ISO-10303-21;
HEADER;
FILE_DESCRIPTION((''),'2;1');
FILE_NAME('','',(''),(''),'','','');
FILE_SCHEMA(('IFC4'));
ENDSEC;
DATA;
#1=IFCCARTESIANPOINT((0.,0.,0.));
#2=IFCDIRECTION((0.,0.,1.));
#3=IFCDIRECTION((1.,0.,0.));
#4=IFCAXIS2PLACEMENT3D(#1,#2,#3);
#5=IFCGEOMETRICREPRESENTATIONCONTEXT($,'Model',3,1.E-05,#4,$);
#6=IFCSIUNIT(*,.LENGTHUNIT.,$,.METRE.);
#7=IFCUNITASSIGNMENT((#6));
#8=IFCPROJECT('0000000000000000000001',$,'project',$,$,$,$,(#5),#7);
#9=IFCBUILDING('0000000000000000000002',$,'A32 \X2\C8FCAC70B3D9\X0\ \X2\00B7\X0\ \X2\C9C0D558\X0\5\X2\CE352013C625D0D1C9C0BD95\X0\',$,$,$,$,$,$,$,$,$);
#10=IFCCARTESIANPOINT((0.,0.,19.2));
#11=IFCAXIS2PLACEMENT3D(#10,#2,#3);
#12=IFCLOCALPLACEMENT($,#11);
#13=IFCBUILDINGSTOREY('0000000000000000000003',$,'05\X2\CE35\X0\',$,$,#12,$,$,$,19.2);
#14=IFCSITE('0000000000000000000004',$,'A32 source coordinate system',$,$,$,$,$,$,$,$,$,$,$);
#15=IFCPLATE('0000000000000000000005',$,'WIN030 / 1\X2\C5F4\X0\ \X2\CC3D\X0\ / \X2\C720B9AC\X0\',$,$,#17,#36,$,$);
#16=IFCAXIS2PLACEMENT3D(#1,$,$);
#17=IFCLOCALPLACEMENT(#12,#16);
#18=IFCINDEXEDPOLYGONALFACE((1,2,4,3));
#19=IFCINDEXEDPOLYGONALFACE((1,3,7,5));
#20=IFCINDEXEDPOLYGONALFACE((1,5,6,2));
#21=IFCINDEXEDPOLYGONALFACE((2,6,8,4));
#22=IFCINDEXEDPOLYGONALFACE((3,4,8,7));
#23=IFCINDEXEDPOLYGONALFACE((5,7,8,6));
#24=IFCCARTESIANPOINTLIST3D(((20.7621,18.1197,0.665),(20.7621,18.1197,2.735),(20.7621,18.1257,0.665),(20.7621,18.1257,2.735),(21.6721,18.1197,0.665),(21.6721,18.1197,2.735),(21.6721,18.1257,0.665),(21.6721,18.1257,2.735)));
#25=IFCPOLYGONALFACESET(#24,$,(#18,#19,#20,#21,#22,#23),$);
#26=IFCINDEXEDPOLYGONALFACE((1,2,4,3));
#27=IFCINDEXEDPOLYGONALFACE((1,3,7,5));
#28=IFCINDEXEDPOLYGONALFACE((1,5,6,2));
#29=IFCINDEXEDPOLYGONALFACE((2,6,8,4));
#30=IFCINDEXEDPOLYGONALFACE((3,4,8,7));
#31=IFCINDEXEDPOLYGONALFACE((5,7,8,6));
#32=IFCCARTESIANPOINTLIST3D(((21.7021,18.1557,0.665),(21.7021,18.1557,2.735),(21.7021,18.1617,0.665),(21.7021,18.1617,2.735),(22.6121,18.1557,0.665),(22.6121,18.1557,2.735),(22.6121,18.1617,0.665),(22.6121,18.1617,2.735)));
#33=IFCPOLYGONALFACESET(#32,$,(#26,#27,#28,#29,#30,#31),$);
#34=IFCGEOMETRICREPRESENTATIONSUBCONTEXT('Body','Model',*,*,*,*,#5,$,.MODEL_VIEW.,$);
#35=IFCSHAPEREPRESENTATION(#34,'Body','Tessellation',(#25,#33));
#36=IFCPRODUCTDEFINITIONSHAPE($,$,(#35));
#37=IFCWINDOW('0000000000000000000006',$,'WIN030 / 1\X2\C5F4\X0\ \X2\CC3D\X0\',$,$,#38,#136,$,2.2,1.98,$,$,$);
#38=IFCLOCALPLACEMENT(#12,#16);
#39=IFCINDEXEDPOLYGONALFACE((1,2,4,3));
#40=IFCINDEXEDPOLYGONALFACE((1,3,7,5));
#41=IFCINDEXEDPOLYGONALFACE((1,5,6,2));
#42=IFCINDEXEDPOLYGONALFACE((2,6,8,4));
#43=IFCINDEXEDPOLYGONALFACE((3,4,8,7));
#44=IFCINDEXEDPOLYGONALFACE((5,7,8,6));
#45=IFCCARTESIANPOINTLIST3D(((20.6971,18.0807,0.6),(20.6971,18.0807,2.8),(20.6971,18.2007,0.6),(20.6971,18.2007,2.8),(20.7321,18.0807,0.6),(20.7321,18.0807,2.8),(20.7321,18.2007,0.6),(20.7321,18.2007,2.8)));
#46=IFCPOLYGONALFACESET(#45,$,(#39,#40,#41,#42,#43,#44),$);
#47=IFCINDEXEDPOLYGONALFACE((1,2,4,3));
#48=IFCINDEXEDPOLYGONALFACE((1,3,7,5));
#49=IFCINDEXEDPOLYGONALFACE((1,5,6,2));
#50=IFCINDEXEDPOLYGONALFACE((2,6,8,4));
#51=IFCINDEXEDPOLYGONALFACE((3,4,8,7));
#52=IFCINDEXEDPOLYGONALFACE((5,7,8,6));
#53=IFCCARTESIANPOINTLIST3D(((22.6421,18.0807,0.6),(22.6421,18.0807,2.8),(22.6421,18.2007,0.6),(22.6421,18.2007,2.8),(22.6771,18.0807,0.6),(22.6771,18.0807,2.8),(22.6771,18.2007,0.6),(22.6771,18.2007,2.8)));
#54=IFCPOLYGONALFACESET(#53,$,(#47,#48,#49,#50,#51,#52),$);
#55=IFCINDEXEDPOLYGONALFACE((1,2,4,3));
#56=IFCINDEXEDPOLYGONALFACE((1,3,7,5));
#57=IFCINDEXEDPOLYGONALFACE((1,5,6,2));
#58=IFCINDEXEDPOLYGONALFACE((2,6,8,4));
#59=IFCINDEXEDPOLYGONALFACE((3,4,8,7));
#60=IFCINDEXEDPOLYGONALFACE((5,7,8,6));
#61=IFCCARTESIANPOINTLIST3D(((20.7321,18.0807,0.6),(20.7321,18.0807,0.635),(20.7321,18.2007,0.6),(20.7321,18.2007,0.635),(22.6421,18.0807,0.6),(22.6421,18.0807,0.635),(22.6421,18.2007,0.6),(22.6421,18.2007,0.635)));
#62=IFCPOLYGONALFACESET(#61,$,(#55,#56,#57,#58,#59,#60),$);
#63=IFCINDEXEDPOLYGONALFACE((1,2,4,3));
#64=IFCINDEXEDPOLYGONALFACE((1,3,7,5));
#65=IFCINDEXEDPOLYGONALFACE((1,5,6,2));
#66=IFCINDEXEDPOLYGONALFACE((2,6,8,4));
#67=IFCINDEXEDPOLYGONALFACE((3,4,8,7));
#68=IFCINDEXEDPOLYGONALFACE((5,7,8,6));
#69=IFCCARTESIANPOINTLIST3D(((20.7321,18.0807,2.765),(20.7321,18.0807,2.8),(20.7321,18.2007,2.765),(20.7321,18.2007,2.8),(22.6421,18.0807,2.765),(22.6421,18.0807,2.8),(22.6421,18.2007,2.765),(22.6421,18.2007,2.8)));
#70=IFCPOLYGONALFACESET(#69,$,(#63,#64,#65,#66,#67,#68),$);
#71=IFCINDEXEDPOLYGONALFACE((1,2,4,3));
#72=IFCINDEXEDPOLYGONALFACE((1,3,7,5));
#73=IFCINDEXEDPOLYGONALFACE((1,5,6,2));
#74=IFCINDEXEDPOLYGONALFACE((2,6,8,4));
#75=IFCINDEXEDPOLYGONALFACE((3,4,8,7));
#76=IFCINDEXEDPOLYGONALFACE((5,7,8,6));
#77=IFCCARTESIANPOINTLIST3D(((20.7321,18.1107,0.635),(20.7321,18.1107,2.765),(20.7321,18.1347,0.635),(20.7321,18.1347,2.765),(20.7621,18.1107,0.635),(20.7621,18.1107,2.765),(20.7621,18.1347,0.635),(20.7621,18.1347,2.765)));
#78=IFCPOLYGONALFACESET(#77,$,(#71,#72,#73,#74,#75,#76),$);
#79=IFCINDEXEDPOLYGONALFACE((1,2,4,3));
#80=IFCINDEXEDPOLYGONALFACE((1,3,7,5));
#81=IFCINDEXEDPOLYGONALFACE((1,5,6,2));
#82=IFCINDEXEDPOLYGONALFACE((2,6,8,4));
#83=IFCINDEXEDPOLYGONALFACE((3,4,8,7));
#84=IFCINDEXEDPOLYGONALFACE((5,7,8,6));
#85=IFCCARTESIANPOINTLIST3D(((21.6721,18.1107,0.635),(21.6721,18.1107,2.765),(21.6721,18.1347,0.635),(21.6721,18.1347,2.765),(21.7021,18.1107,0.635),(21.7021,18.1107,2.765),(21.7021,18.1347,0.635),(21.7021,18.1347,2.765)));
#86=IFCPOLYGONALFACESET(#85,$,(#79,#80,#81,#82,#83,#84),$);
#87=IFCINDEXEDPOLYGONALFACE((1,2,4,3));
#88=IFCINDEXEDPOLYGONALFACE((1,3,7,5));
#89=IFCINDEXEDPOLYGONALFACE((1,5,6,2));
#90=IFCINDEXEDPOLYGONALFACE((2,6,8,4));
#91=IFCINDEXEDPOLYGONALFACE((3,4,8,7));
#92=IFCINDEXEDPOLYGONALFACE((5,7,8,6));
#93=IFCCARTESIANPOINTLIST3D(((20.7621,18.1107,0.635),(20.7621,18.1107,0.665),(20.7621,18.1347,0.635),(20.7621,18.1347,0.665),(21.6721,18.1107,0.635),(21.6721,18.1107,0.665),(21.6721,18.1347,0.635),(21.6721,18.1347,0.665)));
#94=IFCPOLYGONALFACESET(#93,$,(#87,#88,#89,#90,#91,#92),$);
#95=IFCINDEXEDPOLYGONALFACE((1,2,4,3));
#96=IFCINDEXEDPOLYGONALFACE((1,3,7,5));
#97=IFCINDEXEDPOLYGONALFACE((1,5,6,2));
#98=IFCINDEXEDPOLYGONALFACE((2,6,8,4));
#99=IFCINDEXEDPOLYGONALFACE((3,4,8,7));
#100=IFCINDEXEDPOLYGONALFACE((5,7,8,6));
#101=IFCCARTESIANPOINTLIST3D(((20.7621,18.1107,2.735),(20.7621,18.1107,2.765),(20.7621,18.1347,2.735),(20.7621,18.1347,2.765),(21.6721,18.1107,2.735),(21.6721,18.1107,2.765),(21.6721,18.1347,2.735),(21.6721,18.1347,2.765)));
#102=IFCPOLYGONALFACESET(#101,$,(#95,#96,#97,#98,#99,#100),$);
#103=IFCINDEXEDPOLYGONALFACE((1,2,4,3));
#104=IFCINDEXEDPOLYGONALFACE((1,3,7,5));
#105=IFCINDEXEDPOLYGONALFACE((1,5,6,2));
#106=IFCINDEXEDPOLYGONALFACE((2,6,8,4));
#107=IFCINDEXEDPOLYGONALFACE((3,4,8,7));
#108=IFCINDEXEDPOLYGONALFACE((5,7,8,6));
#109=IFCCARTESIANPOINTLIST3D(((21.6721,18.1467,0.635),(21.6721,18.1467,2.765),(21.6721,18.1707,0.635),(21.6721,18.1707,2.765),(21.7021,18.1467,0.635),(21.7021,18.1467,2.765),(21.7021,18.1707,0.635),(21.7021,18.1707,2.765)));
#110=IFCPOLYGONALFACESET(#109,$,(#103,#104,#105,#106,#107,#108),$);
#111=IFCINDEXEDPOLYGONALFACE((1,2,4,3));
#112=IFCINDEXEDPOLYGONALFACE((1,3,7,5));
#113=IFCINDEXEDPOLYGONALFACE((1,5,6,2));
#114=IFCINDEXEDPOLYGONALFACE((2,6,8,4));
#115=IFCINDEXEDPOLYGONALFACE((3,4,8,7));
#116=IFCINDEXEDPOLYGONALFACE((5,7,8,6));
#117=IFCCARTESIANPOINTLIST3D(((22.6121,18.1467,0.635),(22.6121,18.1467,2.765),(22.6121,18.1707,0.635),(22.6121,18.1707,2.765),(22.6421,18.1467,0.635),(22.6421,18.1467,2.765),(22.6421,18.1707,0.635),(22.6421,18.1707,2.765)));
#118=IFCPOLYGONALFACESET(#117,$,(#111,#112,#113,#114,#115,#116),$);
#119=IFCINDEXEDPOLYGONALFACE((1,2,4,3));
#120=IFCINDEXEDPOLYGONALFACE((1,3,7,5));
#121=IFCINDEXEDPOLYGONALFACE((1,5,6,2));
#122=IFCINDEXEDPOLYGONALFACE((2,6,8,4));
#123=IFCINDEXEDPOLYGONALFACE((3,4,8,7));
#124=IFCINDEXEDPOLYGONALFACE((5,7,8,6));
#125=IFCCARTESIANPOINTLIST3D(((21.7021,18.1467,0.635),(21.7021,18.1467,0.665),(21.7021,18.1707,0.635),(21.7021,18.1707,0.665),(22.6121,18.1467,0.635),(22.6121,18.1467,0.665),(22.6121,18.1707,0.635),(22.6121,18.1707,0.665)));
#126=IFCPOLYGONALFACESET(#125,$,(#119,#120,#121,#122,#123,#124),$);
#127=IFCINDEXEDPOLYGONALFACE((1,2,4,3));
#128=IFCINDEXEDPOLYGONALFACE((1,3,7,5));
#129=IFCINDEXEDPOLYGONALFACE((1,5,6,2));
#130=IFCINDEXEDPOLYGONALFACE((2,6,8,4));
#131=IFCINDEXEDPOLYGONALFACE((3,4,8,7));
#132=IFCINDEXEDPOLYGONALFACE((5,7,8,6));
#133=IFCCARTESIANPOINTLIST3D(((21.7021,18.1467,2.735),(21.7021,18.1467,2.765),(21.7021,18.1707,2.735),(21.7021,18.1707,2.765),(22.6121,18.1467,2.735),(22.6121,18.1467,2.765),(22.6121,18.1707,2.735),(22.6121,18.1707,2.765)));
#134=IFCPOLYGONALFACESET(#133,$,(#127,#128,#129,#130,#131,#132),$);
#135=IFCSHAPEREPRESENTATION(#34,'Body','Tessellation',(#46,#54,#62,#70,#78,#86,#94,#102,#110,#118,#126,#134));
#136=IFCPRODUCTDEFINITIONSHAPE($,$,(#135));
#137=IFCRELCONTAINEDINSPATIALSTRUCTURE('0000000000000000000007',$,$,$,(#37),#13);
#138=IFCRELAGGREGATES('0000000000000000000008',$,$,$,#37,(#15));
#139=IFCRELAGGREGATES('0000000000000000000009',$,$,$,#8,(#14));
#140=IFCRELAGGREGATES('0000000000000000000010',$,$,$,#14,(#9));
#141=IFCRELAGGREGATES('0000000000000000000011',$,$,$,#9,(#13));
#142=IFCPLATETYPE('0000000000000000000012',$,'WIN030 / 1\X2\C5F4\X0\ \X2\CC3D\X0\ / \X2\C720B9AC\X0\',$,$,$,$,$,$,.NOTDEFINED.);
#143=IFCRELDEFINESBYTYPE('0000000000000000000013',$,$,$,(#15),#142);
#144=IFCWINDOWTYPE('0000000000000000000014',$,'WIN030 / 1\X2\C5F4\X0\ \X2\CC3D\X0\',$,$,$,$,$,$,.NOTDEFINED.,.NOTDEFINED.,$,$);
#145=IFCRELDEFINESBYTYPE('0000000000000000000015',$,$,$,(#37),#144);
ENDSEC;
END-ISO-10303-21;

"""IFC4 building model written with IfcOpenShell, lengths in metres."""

from ifc_helpers import new_model, si_unit, frame, origin, origin_with_axes, place, context, subcontext, project, spatial, polyline, outline, extrude, source, transform, mapped, type_object, type_shapes, element, aggregate, save


model = new_model("IFC4")

# Units and contexts
model_context = context("Model", 3, precision=1e-05, world=origin_with_axes())
body_context = subcontext(model_context, "Body", "Model", "MODEL_VIEW")
ifc_project = project(units=[si_unit("LENGTHUNIT", "METRE")], contexts=[model_context])

# Plate
storey_placement = place(None, frame((0.0, 0.0, 19.2), z_axis=(0.0, 0.0, 1.0), x_axis=(1.0, 0.0, 0.0)))
plate_type_1 = type_object("IfcPlateType", Name="WIN030 / 1열 창 / 유리", PredefinedType="NOTDEFINED")
shared_shape_1 = source(origin(), body_context, "Body", "SweptSolid", [
    extrude(outline(polyline([(20.7621, 18.1197), (20.7621, 18.1257), (21.6721, 18.1257), (21.6721, 18.1197), (20.7621, 18.1197)])), frame((0.0, 0.0, 0.665)), (0.0, 0.0, 1.0), 2.07),
    extrude(outline(polyline([(21.7021, 18.1557), (21.7021, 18.1617), (22.6121, 18.1617), (22.6121, 18.1557), (21.7021, 18.1557)])), frame((0.0, 0.0, 0.665)), (0.0, 0.0, 1.0), 2.07),
])
type_shapes(plate_type_1, [shared_shape_1])
window_1_placement = place(storey_placement, origin_with_axes())
plate_1_placement = place(window_1_placement, origin_with_axes())
plate_1 = element("IfcPlate", 1, at=plate_1_placement, type_object=plate_type_1, Name="WIN030 / 1열 창 / 유리", context=body_context, shape_type="MappedRepresentation", body=[
    mapped(shared_shape_1, transform((0.0, 0.0, 0.0), scale=1.0)),
])

# Site, building, storey
site = spatial("IfcSite", under=ifc_project, Name="A32 source coordinate system")
building = spatial("IfcBuilding", under=site, Name="A32 주거동 · 지하5층–옥탑지붕")
storey = spatial("IfcBuildingStorey", under=building, at=storey_placement, Name="05층", Elevation=19.2)

# Window
window_type_1 = type_object("IfcWindowType", Name="WIN030 / 1열 창", PartitioningType="NOTDEFINED", PredefinedType="NOTDEFINED")
shared_shape_2 = source(origin(), body_context, "Body", "SweptSolid", [
    extrude(outline(polyline([(20.6971, 18.0807), (20.6971, 18.2007), (20.7321, 18.2007), (20.7321, 18.0807), (20.6971, 18.0807)])), frame((0.0, 0.0, 0.6)), (0.0, 0.0, 1.0), 2.2),
    extrude(outline(polyline([(22.6421, 18.0807), (22.6421, 18.2007), (22.6771, 18.2007), (22.6771, 18.0807), (22.6421, 18.0807)])), frame((0.0, 0.0, 0.6)), (0.0, 0.0, 1.0), 2.2),
    extrude(outline(polyline([(20.7321, 18.0807), (20.7321, 18.2007), (22.6421, 18.2007), (22.6421, 18.0807), (20.7321, 18.0807)])), frame((0.0, 0.0, 0.6)), (0.0, 0.0, 1.0), 0.035),
    extrude(outline(polyline([(20.7321, 18.0807), (20.7321, 18.2007), (22.6421, 18.2007), (22.6421, 18.0807), (20.7321, 18.0807)])), frame((0.0, 0.0, 2.765)), (0.0, 0.0, 1.0), 0.035),
    extrude(outline(polyline([(20.7321, 18.1107), (20.7321, 18.1347), (20.7621, 18.1347), (20.7621, 18.1107), (20.7321, 18.1107)])), frame((0.0, 0.0, 0.635)), (0.0, 0.0, 1.0), 2.13),
    extrude(outline(polyline([(21.6721, 18.1107), (21.6721, 18.1347), (21.7021, 18.1347), (21.7021, 18.1107), (21.6721, 18.1107)])), frame((0.0, 0.0, 0.635)), (0.0, 0.0, 1.0), 2.13),
    extrude(outline(polyline([(20.7621, 18.1107), (20.7621, 18.1347), (21.6721, 18.1347), (21.6721, 18.1107), (20.7621, 18.1107)])), frame((0.0, 0.0, 0.635)), (0.0, 0.0, 1.0), 0.03),
    extrude(outline(polyline([(20.7621, 18.1107), (20.7621, 18.1347), (21.6721, 18.1347), (21.6721, 18.1107), (20.7621, 18.1107)])), frame((0.0, 0.0, 2.735)), (0.0, 0.0, 1.0), 0.03),
    extrude(outline(polyline([(21.6721, 18.1467), (21.6721, 18.1707), (21.7021, 18.1707), (21.7021, 18.1467), (21.6721, 18.1467)])), frame((0.0, 0.0, 0.635)), (0.0, 0.0, 1.0), 2.13),
    extrude(outline(polyline([(22.6121, 18.1467), (22.6121, 18.1707), (22.6421, 18.1707), (22.6421, 18.1467), (22.6121, 18.1467)])), frame((0.0, 0.0, 0.635)), (0.0, 0.0, 1.0), 2.13),
    extrude(outline(polyline([(21.7021, 18.1467), (21.7021, 18.1707), (22.6121, 18.1707), (22.6121, 18.1467), (21.7021, 18.1467)])), frame((0.0, 0.0, 0.635)), (0.0, 0.0, 1.0), 0.03),
    extrude(outline(polyline([(21.7021, 18.1467), (21.7021, 18.1707), (22.6121, 18.1707), (22.6121, 18.1467), (21.7021, 18.1467)])), frame((0.0, 0.0, 2.735)), (0.0, 0.0, 1.0), 0.03),
])
type_shapes(window_type_1, [shared_shape_2])
window_1 = element("IfcWindow", 2, at=window_1_placement, inside=storey, type_object=window_type_1, Name="WIN030 / 1열 창", OverallHeight=2.2, OverallWidth=1.98, context=body_context, shape_type="MappedRepresentation", body=[
    mapped(shared_shape_2, transform((0.0, 0.0, 0.0), scale=1.0)),
])
aggregate(window_1, [plate_1])

save(model, "model.ifc")
